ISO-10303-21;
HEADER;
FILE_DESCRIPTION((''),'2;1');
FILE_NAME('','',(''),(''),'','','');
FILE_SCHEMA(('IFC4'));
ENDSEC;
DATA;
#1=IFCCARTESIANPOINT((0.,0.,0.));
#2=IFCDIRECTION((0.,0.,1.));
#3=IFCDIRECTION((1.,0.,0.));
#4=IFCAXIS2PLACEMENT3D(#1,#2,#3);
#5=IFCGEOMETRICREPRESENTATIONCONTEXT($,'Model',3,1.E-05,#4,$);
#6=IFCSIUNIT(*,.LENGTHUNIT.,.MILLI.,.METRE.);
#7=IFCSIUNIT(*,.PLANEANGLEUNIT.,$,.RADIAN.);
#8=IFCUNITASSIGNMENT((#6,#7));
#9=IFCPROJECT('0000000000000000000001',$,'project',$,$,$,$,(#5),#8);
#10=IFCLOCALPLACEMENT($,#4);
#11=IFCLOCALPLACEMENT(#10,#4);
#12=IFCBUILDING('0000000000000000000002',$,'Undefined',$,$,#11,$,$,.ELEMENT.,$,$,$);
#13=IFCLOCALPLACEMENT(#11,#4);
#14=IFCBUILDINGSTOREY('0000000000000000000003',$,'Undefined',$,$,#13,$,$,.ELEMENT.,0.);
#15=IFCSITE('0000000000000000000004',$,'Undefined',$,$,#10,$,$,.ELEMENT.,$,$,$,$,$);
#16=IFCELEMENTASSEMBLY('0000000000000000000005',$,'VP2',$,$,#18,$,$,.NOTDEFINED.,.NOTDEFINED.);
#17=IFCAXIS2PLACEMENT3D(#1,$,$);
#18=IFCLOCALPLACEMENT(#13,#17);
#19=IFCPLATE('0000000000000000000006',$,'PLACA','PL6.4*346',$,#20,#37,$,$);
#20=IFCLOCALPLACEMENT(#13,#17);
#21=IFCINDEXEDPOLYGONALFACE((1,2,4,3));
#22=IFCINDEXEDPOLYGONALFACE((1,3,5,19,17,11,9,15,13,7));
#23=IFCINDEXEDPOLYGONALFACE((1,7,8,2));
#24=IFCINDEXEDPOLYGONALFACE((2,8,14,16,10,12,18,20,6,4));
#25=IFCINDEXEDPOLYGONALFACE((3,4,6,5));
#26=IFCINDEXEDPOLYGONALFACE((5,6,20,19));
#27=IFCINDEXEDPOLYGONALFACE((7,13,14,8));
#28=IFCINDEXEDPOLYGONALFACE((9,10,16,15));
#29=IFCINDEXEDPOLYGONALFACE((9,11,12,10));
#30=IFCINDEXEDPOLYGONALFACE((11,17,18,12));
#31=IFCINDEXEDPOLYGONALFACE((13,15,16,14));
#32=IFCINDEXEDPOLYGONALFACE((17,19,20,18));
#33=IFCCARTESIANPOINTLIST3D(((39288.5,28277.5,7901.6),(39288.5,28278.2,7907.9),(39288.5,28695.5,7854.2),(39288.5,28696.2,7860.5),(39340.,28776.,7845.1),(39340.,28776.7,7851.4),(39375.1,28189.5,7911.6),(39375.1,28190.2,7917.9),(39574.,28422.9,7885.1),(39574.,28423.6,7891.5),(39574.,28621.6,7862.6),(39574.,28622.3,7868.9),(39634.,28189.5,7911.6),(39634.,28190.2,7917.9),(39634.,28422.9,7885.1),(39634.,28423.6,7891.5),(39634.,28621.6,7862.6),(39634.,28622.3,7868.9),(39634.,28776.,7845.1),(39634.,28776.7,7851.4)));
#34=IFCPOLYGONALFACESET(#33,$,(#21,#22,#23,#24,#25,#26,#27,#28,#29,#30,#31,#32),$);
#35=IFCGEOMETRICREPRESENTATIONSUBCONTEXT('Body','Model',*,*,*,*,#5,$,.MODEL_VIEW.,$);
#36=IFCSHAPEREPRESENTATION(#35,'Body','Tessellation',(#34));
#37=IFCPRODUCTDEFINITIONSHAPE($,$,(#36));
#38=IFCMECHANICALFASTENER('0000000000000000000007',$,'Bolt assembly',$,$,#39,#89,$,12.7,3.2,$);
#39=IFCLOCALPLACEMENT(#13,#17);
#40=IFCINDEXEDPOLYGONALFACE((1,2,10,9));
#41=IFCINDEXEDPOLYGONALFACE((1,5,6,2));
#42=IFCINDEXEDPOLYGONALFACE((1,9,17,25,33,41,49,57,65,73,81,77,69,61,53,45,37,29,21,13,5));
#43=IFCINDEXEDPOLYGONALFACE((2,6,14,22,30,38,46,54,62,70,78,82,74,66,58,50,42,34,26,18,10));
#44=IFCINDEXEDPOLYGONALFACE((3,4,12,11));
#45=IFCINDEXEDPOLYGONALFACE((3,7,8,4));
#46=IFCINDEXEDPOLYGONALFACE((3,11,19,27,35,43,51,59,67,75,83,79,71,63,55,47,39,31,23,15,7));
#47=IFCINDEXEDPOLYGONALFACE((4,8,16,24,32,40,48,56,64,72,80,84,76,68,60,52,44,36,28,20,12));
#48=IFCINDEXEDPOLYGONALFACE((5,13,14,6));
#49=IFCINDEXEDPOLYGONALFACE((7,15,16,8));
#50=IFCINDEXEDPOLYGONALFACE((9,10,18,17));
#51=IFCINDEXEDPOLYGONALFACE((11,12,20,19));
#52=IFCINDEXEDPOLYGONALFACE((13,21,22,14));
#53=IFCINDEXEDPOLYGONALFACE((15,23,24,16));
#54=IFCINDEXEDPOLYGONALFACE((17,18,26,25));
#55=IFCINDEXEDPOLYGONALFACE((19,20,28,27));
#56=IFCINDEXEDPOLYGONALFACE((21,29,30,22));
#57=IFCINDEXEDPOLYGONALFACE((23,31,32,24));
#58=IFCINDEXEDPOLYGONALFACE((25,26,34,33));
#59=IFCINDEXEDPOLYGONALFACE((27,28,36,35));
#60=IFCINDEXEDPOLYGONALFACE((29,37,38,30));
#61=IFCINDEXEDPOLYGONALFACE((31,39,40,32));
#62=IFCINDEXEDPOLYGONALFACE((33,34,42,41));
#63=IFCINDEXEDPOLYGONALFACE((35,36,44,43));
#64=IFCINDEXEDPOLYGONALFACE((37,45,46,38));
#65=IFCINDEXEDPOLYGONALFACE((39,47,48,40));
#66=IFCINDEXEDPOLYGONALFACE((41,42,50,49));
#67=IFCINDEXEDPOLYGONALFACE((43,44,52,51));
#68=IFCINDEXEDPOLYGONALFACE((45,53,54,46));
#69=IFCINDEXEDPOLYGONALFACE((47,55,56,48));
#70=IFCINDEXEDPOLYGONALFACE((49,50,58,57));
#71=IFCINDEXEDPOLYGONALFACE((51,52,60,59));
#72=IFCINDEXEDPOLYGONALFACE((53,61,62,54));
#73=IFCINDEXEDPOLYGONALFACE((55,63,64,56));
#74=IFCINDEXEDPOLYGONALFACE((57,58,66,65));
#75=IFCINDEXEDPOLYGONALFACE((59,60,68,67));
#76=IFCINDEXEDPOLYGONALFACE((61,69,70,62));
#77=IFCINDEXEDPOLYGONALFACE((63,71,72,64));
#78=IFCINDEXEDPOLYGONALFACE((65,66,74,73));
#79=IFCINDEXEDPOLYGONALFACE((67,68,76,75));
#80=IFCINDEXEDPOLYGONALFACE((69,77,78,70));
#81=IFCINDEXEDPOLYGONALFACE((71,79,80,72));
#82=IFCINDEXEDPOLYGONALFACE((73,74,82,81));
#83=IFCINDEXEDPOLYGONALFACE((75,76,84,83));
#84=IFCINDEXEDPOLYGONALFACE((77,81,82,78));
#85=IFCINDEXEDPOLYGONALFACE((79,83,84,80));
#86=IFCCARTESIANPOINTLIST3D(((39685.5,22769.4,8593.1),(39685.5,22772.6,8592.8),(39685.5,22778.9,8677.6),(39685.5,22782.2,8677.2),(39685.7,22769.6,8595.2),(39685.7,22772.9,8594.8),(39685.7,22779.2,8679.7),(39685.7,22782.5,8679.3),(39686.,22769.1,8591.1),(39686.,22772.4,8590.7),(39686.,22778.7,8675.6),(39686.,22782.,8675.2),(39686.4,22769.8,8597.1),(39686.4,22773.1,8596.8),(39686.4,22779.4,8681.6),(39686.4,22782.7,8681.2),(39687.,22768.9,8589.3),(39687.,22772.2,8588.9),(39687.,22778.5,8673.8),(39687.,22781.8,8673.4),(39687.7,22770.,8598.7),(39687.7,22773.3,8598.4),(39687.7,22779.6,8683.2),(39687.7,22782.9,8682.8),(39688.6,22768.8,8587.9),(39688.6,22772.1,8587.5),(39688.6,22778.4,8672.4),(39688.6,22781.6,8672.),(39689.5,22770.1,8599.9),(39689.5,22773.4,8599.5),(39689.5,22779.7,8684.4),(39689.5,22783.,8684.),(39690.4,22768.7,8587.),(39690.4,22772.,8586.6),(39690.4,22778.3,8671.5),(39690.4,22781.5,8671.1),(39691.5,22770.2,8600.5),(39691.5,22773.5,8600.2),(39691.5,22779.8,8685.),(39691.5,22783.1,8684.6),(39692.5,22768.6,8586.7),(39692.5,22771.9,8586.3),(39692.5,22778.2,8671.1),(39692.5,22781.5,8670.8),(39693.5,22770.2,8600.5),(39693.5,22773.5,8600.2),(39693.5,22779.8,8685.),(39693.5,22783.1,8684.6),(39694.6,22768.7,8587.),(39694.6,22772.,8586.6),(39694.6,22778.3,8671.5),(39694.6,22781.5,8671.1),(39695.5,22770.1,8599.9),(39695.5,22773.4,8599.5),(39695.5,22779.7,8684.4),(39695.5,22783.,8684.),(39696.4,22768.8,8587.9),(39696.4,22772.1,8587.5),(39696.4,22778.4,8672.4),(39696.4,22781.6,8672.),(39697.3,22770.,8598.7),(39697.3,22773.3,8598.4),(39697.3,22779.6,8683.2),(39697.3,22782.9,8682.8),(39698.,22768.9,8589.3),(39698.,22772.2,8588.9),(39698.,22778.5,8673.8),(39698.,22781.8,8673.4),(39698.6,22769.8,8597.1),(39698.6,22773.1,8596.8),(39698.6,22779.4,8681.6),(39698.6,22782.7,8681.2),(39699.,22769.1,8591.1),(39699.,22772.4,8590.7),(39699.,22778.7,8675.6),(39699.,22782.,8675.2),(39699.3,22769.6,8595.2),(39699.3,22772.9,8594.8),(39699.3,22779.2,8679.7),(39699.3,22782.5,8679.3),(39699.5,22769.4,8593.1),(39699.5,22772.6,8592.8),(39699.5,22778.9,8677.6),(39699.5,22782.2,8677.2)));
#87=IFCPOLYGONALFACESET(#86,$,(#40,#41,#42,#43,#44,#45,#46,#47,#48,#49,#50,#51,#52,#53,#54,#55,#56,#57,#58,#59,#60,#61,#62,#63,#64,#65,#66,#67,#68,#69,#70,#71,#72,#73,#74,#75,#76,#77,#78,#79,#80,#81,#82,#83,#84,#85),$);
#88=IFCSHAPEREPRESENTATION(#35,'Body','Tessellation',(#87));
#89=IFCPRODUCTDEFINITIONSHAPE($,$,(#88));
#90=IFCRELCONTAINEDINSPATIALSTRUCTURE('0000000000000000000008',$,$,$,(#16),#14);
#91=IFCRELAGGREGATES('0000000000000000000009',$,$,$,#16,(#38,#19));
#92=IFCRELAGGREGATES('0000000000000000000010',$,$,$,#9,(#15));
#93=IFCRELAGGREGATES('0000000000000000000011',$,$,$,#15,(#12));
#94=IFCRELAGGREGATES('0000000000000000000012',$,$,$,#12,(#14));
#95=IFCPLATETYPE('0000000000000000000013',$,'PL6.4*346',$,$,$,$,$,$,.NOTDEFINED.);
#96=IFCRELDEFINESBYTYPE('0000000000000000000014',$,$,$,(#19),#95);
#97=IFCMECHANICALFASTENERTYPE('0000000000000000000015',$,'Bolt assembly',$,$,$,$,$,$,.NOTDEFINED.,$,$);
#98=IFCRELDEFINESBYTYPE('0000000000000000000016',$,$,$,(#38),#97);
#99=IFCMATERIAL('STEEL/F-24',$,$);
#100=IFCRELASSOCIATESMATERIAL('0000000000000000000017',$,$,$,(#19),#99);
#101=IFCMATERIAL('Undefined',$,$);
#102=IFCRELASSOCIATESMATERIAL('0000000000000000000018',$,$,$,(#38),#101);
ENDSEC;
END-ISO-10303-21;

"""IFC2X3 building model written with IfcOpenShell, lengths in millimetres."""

from ifc_helpers import new_model, si_unit, frame, origin_with_axes, origin_2d_with_axis, place, context, subcontext, project, spatial, polyline, circle, outline, extrude, boolean, source, transform, mapped, material, type_object, element, aggregate, save


model = new_model("IFC2X3")

# Units and contexts
model_context = context("Model", 3, precision=1e-05, world=origin_with_axes())
body_context = subcontext(model_context, "Body", "Model", "MODEL_VIEW")
ifc_project = project(units=[si_unit("LENGTHUNIT", "METRE", prefix="MILLI"), si_unit("PLANEANGLEUNIT", "RADIAN")], contexts=[model_context])

# Site, building, storey
site_placement = place(None, origin_with_axes())
site = spatial("IfcSite", under=ifc_project, at=site_placement, Name="Undefined", CompositionType="ELEMENT")
building_placement = place(site_placement, origin_with_axes())
building = spatial("IfcBuilding", under=site, at=building_placement, Name="Undefined", CompositionType="ELEMENT")
storey_placement = place(building_placement, origin_with_axes())
storey = spatial("IfcBuildingStorey", under=building, at=storey_placement, Name="Undefined", CompositionType="ELEMENT", Elevation=0.0)

# Element assembly
assembly_1_placement = place(storey_placement, origin_with_axes())
assembly_1 = element("IfcElementAssembly", 1, at=assembly_1_placement, inside=storey, Name="VP2", AssemblyPlace="NOTDEFINED", PredefinedType="NOTDEFINED")
ifc_material_1 = material(Name="STEEL/F-24")

# Plate
plate_type_1 = type_object("IfcPlateType", Name="PL6.4*346", PredefinedType="NOTDEFINED")
plate_1_placement = place(assembly_1_placement, frame((39634.0, 28189.9, 7914.7), z_axis=(-0.000017, 0.112653, 0.993634), x_axis=(0.0, 0.993634, -0.112653)))
plate_1 = element("IfcPlate", 2, at=plate_1_placement, type_object=plate_type_1, material=ifc_material_1, Name="PLACA", Description="PL6.4*346", context=body_context, shape_type="CSG", body=[
    boolean("DIFFERENCE", extrude(outline(polyline([(0.0, 0.0), (590.2, 0.0), (590.2, 294.0), (509.2, 345.5), (88.6, 345.5), (0.0, 258.9), (0.0, 0.0)])), frame((0.0, 0.0, -3.2), z_axis=(0.0, 0.0, 1.0), x_axis=(1.0, 0.0, 0.0)), (0.0, 0.0, 1.0), 6.4), extrude(outline(polyline([(0.0, 0.0), (60.0, 0.0), (60.0, 200.0), (0.0, 200.0), (0.0, 0.0)])), frame((434.9, 0.0, -7.1), z_axis=(-0.000115, -0.000017, 1.0), x_axis=(0.0, 1.0, 0.000017)), (0.0, 0.0, 1.0), 12.0)),
])

# Mechanical fastener
ifc_material_2 = material(Name="Undefined")
mechanical_fastener_type = type_object("IfcMechanicalFastenerType", Name="Bolt assembly")
shared_shape_1 = source(origin_with_axes(), body_context, "Body", "SweptSolid", [
    extrude(circle(Radius=7.0, at=origin_2d_with_axis()), frame((0.0, -3.2, 0.0), z_axis=(0.0, 1.0, 0.0), x_axis=(1.0, 0.0, 0.0)), (0.0, 0.0, 1.0), 3.3),
])
mechanical_fastener_1_placement = place(assembly_1_placement, frame((39692.5, 22779.1, 8678.1), z_axis=(-1.0, 0.0, 0.0), x_axis=(0.0, -0.112644, -0.993635)))
mechanical_fastener_1 = element("IfcMechanicalFastener", 3, at=mechanical_fastener_1_placement, type_object=mechanical_fastener_type, material=ifc_material_2, Name="Bolt assembly", NominalDiameter=12.7, NominalLength=3.2, context=body_context, shape_type="MappedRepresentation", body=[
    mapped(shared_shape_1, transform((0.0, 0.0, 0.0))),
    mapped(shared_shape_1, transform((85.0, 0.0, 0.0))),
])

aggregate(assembly_1, [mechanical_fastener_1, plate_1])

save(model, "model.ifc")
